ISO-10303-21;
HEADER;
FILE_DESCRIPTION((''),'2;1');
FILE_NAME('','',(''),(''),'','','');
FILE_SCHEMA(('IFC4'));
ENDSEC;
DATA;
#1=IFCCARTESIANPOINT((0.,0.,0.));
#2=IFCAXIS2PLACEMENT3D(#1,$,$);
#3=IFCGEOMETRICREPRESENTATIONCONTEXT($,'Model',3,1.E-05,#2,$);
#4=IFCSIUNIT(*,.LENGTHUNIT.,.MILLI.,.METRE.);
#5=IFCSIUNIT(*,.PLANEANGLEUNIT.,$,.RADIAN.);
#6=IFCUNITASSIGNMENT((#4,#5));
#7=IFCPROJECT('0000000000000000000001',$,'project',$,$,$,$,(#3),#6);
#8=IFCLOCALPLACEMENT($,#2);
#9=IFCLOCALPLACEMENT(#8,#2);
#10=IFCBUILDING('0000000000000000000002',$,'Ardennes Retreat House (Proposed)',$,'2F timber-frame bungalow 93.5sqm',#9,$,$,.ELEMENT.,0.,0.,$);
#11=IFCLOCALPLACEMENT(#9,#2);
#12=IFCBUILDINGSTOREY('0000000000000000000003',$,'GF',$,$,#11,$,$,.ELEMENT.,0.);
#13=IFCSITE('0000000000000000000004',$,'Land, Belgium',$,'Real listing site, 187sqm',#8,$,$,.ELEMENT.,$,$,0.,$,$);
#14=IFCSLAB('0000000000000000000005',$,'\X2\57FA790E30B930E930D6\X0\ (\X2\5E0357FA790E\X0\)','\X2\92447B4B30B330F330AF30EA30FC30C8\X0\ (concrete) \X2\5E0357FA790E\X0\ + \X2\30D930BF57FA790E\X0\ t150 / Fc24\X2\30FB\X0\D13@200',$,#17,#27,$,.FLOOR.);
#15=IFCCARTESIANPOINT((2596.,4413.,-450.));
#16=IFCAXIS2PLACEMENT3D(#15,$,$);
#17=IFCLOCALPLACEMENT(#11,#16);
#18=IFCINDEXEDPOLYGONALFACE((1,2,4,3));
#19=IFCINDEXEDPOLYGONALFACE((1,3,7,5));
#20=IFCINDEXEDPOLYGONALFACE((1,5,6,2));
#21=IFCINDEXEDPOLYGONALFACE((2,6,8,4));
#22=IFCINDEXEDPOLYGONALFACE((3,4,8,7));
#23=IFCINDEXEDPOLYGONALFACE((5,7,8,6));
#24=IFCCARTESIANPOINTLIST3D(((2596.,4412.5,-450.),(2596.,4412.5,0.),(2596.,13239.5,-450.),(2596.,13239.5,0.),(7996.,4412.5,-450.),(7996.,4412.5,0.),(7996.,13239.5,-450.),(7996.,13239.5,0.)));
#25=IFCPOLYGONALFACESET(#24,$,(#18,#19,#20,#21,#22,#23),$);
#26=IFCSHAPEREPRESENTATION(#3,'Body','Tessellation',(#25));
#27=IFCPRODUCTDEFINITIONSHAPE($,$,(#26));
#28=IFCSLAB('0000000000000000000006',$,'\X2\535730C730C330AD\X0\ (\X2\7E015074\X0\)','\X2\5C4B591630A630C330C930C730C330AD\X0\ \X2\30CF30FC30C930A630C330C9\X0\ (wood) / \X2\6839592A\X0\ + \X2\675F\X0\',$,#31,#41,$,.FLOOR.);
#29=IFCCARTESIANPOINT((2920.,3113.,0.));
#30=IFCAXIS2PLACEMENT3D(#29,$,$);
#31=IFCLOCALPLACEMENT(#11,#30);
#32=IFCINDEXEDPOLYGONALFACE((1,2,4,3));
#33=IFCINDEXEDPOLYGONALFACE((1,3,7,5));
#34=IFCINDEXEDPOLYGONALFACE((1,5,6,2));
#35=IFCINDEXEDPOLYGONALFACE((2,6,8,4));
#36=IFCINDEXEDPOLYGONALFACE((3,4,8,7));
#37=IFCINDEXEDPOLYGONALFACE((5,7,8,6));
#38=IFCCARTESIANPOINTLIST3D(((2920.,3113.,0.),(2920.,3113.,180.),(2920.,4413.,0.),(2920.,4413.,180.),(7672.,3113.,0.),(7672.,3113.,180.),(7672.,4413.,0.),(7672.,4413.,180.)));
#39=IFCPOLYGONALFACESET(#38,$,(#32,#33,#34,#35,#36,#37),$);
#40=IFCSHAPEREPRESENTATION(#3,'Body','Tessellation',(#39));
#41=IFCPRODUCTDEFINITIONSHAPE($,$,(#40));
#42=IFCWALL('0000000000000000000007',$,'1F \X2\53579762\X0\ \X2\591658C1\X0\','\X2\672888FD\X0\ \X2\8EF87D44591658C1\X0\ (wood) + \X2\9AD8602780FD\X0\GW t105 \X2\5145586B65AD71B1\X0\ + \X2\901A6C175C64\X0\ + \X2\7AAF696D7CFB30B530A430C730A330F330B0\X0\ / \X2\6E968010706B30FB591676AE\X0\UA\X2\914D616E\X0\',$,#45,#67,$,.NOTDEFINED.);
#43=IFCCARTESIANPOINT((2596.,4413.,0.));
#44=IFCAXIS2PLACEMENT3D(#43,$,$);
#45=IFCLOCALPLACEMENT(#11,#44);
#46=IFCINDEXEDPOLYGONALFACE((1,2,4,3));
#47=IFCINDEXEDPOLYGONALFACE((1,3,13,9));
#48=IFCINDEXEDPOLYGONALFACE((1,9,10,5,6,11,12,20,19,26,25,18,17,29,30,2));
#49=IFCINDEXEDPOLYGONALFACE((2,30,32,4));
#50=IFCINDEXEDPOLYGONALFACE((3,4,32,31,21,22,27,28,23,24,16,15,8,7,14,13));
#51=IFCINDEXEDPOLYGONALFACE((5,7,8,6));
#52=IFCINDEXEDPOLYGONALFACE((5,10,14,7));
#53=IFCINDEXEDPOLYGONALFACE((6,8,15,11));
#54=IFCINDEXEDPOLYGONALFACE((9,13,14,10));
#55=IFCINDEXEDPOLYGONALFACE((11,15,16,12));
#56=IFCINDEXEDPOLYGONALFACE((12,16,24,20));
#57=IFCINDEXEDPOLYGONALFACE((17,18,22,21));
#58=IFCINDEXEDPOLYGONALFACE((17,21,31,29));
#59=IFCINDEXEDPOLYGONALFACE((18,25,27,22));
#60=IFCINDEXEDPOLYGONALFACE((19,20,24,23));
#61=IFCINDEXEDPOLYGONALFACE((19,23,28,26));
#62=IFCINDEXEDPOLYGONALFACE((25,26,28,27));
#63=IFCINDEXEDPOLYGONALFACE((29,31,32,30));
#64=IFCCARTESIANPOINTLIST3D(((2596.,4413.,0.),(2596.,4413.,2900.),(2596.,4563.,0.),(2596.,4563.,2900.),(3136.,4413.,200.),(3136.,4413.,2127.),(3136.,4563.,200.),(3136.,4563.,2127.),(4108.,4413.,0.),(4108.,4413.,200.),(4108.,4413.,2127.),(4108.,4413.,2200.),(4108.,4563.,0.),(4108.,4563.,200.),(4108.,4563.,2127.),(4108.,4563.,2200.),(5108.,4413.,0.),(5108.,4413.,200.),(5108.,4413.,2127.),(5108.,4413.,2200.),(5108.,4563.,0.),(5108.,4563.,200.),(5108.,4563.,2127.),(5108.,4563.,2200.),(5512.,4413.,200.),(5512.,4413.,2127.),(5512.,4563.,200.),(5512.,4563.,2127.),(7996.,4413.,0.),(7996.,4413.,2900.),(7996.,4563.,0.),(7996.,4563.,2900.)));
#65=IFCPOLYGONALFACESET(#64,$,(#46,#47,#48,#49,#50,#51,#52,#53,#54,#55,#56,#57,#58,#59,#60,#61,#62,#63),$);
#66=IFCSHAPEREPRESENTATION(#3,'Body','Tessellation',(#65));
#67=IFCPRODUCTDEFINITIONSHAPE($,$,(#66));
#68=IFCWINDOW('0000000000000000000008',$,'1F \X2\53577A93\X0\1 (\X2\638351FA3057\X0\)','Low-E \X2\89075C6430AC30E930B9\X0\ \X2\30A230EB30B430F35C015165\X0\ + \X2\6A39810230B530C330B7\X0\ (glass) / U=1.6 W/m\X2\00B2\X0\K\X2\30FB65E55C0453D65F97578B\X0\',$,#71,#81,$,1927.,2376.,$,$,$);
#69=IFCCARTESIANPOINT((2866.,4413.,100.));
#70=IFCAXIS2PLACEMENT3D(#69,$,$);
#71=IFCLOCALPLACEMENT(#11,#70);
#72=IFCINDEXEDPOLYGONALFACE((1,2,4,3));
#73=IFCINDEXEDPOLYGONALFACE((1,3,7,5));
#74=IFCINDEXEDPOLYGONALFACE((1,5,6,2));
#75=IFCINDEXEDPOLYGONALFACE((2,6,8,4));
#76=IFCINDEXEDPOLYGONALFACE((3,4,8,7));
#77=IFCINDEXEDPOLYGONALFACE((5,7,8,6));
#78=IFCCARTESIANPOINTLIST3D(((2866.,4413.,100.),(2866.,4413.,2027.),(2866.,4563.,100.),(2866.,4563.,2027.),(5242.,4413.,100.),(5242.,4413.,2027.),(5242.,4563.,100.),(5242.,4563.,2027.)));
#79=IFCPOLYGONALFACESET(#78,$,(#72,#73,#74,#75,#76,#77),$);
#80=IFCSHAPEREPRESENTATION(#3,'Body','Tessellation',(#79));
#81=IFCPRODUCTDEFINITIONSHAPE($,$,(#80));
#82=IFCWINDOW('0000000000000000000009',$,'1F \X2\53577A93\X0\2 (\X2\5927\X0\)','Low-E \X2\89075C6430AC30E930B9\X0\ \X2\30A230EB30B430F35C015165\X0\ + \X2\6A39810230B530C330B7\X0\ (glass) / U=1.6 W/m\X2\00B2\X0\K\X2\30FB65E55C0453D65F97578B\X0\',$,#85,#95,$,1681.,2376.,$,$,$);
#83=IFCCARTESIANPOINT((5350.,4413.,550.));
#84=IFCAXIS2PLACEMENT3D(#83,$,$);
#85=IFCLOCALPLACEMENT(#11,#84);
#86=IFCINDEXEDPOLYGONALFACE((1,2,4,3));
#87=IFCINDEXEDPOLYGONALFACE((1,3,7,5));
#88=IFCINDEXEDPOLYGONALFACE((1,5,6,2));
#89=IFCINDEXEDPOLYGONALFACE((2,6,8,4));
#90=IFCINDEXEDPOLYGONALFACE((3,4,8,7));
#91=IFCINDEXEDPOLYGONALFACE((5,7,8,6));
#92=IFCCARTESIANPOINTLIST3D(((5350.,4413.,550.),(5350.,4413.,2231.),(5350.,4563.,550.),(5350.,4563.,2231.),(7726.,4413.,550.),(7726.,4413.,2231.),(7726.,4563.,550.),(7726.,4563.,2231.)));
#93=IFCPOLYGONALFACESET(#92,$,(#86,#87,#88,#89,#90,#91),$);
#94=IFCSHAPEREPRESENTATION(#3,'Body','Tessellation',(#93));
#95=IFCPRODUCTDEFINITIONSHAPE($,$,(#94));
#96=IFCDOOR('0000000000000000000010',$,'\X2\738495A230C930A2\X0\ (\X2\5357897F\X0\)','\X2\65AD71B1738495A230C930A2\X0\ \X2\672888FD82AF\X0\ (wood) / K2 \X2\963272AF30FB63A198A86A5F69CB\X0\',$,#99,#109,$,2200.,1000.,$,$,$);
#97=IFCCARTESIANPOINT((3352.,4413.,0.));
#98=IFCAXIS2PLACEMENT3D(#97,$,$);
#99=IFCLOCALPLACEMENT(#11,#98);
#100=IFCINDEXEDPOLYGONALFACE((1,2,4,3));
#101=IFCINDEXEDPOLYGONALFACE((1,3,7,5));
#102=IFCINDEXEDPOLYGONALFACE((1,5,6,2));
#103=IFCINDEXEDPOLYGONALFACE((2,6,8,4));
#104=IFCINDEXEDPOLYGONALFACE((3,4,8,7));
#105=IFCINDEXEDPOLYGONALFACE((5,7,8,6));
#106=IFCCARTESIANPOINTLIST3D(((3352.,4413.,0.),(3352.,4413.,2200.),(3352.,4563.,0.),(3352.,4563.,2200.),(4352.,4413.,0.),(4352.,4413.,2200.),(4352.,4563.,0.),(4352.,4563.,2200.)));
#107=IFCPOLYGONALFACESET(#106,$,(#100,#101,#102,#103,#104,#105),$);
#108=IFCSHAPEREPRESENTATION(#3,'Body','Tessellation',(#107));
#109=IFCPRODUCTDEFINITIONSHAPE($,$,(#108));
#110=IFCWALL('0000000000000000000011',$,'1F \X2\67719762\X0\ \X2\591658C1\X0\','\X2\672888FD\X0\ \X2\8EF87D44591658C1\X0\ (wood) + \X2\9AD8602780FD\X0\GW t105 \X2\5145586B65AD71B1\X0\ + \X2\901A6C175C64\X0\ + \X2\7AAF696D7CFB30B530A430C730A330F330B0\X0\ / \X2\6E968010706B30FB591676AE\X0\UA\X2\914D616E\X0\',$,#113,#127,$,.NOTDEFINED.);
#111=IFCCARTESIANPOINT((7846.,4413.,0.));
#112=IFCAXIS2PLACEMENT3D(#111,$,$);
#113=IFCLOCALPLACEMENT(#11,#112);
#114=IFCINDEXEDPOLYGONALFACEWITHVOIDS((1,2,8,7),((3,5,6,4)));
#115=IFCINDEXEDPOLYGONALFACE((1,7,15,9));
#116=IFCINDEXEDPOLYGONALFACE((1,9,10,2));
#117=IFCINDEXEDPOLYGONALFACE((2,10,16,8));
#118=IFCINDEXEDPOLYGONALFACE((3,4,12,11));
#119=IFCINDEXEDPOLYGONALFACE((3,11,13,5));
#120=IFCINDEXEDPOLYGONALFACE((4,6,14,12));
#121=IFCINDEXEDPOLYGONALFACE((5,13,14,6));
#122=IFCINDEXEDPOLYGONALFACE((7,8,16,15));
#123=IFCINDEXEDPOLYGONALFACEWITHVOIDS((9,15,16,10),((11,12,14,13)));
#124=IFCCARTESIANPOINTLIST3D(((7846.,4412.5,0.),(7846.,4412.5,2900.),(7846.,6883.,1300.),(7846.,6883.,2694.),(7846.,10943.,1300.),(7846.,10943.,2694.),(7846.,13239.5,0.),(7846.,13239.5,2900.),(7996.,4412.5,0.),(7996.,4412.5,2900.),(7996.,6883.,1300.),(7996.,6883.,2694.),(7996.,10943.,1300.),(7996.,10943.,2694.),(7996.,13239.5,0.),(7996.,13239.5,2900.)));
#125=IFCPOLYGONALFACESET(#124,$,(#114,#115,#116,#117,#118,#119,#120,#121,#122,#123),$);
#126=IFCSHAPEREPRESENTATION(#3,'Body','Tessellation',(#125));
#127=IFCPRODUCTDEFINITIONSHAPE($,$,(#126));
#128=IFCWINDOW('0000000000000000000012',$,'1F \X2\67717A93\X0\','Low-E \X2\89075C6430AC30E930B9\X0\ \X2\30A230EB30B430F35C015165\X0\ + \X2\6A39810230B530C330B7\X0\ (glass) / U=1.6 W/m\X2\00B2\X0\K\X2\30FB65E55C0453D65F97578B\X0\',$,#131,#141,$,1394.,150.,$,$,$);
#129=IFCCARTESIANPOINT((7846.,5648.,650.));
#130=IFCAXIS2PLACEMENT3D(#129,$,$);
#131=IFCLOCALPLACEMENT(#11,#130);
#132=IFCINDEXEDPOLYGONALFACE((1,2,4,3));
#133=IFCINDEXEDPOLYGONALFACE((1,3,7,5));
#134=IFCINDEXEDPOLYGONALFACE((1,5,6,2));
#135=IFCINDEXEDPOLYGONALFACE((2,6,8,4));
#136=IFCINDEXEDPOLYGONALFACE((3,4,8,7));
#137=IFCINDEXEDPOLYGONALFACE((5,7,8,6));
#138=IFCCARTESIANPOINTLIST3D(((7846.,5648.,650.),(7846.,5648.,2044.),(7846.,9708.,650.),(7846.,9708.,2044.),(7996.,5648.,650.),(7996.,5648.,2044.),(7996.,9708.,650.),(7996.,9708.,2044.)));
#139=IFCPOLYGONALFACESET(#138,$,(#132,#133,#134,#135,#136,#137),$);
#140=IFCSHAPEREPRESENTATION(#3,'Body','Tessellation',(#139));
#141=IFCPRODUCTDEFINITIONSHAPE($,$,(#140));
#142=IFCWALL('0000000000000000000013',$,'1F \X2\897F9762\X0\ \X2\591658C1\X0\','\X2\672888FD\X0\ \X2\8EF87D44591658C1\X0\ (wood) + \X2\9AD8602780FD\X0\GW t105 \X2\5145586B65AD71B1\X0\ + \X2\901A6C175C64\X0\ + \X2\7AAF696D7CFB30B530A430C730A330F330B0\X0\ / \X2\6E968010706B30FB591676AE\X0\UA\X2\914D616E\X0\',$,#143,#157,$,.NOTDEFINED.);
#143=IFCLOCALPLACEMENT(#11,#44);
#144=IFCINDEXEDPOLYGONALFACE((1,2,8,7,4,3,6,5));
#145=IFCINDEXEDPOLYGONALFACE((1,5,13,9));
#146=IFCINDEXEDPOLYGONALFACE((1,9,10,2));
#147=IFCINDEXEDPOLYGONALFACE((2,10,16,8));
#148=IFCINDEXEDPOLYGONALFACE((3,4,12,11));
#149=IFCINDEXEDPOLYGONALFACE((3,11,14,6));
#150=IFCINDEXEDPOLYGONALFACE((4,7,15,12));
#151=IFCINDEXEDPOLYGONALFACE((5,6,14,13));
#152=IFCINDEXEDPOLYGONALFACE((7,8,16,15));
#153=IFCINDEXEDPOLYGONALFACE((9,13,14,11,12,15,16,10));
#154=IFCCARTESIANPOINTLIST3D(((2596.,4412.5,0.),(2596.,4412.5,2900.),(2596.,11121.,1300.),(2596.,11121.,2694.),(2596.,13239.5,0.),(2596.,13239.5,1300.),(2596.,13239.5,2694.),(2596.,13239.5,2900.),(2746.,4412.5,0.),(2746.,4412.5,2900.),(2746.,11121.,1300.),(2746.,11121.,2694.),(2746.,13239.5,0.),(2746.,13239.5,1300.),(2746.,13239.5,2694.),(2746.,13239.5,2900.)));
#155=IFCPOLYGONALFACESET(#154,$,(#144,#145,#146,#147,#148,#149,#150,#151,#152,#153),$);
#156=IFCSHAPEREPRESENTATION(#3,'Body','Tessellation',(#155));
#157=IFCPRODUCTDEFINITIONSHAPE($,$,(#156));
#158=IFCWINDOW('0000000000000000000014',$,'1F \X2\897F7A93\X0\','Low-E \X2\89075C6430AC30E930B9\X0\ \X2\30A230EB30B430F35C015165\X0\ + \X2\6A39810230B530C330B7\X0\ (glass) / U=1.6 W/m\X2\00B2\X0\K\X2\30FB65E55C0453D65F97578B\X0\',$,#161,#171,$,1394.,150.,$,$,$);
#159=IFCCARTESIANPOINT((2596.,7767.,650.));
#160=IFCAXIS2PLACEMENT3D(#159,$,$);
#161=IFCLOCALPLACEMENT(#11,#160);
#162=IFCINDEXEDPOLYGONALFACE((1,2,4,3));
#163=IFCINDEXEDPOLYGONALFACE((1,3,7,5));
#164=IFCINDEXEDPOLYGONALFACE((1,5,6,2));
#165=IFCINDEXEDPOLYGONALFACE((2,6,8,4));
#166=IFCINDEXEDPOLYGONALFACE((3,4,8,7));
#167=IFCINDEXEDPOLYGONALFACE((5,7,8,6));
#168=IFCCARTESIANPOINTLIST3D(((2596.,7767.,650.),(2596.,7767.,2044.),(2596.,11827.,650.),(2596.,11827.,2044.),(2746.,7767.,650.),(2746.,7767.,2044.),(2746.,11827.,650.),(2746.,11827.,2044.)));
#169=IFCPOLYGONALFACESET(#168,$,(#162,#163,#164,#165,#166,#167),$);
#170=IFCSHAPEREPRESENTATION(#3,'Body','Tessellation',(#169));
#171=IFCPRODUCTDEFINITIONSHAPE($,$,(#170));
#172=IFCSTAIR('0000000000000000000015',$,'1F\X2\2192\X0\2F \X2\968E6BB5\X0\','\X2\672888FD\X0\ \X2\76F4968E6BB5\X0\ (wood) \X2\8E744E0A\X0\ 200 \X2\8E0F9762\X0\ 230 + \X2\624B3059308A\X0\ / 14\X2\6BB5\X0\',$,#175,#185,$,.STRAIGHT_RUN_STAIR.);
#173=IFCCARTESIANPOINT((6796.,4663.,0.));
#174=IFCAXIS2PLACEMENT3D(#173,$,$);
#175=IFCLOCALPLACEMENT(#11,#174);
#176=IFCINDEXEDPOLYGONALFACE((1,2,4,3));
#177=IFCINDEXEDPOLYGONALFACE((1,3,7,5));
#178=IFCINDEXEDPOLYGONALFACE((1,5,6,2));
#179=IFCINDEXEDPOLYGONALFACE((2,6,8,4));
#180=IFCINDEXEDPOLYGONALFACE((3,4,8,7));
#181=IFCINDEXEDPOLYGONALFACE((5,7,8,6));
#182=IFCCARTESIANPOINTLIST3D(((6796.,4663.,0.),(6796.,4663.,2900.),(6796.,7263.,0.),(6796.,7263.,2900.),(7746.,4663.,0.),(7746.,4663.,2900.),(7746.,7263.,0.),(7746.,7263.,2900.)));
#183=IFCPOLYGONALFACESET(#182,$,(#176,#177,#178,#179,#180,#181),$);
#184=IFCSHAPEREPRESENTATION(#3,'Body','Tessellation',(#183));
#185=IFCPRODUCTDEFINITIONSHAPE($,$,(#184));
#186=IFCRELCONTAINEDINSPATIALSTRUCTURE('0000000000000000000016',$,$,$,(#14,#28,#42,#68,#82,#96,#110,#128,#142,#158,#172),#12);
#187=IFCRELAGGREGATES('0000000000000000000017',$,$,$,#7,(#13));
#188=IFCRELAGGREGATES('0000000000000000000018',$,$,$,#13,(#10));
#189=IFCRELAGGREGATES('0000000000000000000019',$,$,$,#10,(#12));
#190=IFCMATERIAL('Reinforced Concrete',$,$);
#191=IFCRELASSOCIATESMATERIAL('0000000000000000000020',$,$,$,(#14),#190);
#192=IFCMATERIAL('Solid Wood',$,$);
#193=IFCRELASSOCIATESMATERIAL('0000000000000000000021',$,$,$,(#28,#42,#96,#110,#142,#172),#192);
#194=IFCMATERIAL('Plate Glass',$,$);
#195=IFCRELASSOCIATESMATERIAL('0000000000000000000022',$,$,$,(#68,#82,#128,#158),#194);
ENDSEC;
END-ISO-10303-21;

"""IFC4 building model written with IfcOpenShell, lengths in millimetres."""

from ifc_helpers import new_model, si_unit, frame, frame_2d, origin, place, context, project, spatial, rectangle, extrude, material, element, fill, save


model = new_model("IFC4")

# Units and contexts
model_context = context("Model", 3, precision=1e-05, world=origin())
ifc_project = project(units=[si_unit("LENGTHUNIT", "METRE", prefix="MILLI"), si_unit("PLANEANGLEUNIT", "RADIAN")], contexts=[model_context])

# Site, building, storey
site_placement = place(None, origin())
site = spatial("IfcSite", under=ifc_project, at=site_placement, Name="Land, Belgium", ObjectType="Real listing site, 187sqm", CompositionType="ELEMENT", RefElevation=0.0)
building_placement = place(site_placement, origin())
building = spatial("IfcBuilding", under=site, at=building_placement, Name="Ardennes Retreat House (Proposed)", ObjectType="2F timber-frame bungalow 93.5sqm", CompositionType="ELEMENT", ElevationOfRefHeight=0.0, ElevationOfTerrain=0.0)
storey_placement = place(building_placement, origin())
storey = spatial("IfcBuildingStorey", under=building, at=storey_placement, Name="GF", CompositionType="ELEMENT", Elevation=0.0)

# Slabs
ifc_material_1 = material(Name="Reinforced Concrete")
slab_1_placement = place(storey_placement, frame((2596.0, 4413.0, -450.0)))
element("IfcSlab", 1, at=slab_1_placement, inside=storey, material=ifc_material_1, Name="基礎スラブ (布基礎)", Description="鉄筋コンクリート (concrete) 布基礎 + ベタ基礎 t150 / Fc24・D13@200", PredefinedType="FLOOR", context=model_context, shape_type="SweptSolid", body=[
    extrude(rectangle(XDim=5400.0, YDim=8827.0, at=frame_2d((2700.0, 4413.0))), frame((2596.0, 4413.0, -450.0)), (0.0, 0.0, 1.0), 450.0),
])
ifc_material_2 = material(Name="Solid Wood")
slab_2_placement = place(storey_placement, frame((2920.0, 3113.0, 0.0)))
element("IfcSlab", 2, at=slab_2_placement, inside=storey, material=ifc_material_2, Name="南デッキ (縁側)", Description="屋外ウッドデッキ ハードウッド (wood) / 根太 + 束", PredefinedType="FLOOR", context=model_context, shape_type="SweptSolid", body=[
    extrude(rectangle(XDim=4752.0, YDim=1300.0, at=frame_2d((2376.0, 650.0))), frame((2920.0, 3113.0, 0.0)), (0.0, 0.0, 1.0), 180.0),
])

# Wall, openings, windows, door
wall_1_placement = place(storey_placement, frame((2596.0, 4413.0, 0.0)))
wall_1 = element("IfcWall", 3, at=wall_1_placement, inside=storey, material=ifc_material_2, Name="1F 南面 外壁", Description="木製 軸組外壁 (wood) + 高性能GW t105 充填断熱 + 通気層 + 窯業系サイディング / 準耐火・外皮UA配慮", PredefinedType="NOTDEFINED", context=model_context, shape_type="SweptSolid", body=[
    extrude(rectangle(XDim=5400.0, YDim=150.0, at=frame_2d((2700.0, 75.0))), frame((2596.0, 4413.0, 0.0)), (0.0, 0.0, 1.0), 2900.0),
])
opening_1_placement = place(storey_placement, frame((2866.0, 4413.0, 100.0)))
opening_1 = element("IfcOpeningElement", 4, at=opening_1_placement, cuts=wall_1, PredefinedType="NOTDEFINED", context=model_context, shape_type="SweptSolid", body=[
    extrude(rectangle(XDim=2376.0, YDim=150.0, at=frame_2d((1188.0, 75.0))), frame((2866.0, 4413.0, 100.0)), (0.0, 0.0, 1.0), 1927.0),
])
opening_2_placement = place(storey_placement, frame((5350.0, 4413.0, 550.0)))
opening_2 = element("IfcOpeningElement", 5, at=opening_2_placement, cuts=wall_1, PredefinedType="NOTDEFINED", context=model_context, shape_type="SweptSolid", body=[
    extrude(rectangle(XDim=2376.0, YDim=150.0, at=frame_2d((1188.0, 75.0))), frame((5350.0, 4413.0, 550.0)), (0.0, 0.0, 1.0), 1681.0),
])
opening_3_placement = place(storey_placement, frame((3352.0, 4413.0, 0.0)))
opening_3 = element("IfcOpeningElement", 6, at=opening_3_placement, cuts=wall_1, PredefinedType="NOTDEFINED", context=model_context, shape_type="SweptSolid", body=[
    extrude(rectangle(XDim=1000.0, YDim=150.0, at=frame_2d((500.0, 75.0))), frame((3352.0, 4413.0, 0.0)), (0.0, 0.0, 1.0), 2200.0),
])
ifc_material_3 = material(Name="Plate Glass")
window_1_placement = place(storey_placement, frame((2866.0, 4413.0, 100.0)))
window_1 = element("IfcWindow", 7, at=window_1_placement, inside=storey, material=ifc_material_3, Name="1F 南窓1 (掃出し)", Description="Low-E 複層ガラス アルゴン封入 + 樹脂サッシ (glass) / U=1.6 W/m²K・日射取得型", OverallHeight=1927.0, OverallWidth=2376.0, context=model_context, shape_type="SweptSolid", body=[
    extrude(rectangle(XDim=2376.0, YDim=150.0, at=frame_2d((1188.0, 75.0))), frame((2866.0, 4413.0, 100.0)), (0.0, 0.0, 1.0), 1927.0),
])
fill(opening_1, window_1)
window_2_placement = place(storey_placement, frame((5350.0, 4413.0, 550.0)))
window_2 = element("IfcWindow", 8, at=window_2_placement, inside=storey, material=ifc_material_3, Name="1F 南窓2 (大)", Description="Low-E 複層ガラス アルゴン封入 + 樹脂サッシ (glass) / U=1.6 W/m²K・日射取得型", OverallHeight=1681.0, OverallWidth=2376.0, context=model_context, shape_type="SweptSolid", body=[
    extrude(rectangle(XDim=2376.0, YDim=150.0, at=frame_2d((1188.0, 75.0))), frame((5350.0, 4413.0, 550.0)), (0.0, 0.0, 1.0), 1681.0),
])
fill(opening_2, window_2)
door_placement = place(storey_placement, frame((3352.0, 4413.0, 0.0)))
door = element("IfcDoor", 9, at=door_placement, inside=storey, material=ifc_material_2, Name="玄関ドア (南西)", Description="断熱玄関ドア 木製芯 (wood) / K2 防犯・採風機構", OverallHeight=2200.0, OverallWidth=1000.0, context=model_context, shape_type="SweptSolid", body=[
    extrude(rectangle(XDim=1000.0, YDim=150.0, at=frame_2d((500.0, 75.0))), frame((3352.0, 4413.0, 0.0)), (0.0, 0.0, 1.0), 2200.0),
])
fill(opening_3, door)

# Walls, openings, windows
wall_2_placement = place(storey_placement, frame((7846.0, 4413.0, 0.0)))
wall_2 = element("IfcWall", 10, at=wall_2_placement, inside=storey, material=ifc_material_2, Name="1F 東面 外壁", Description="木製 軸組外壁 (wood) + 高性能GW t105 充填断熱 + 通気層 + 窯業系サイディング / 準耐火・外皮UA配慮", PredefinedType="NOTDEFINED", context=model_context, shape_type="SweptSolid", body=[
    extrude(rectangle(XDim=150.0, YDim=8827.0, at=frame_2d((75.0, 4413.0))), frame((7846.0, 4413.0, 0.0)), (0.0, 0.0, 1.0), 2900.0),
])
opening_4_placement = place(storey_placement, frame((7846.0, 5648.0, 650.0)))
opening_4 = element("IfcOpeningElement", 11, at=opening_4_placement, cuts=wall_2, PredefinedType="NOTDEFINED", context=model_context, shape_type="SweptSolid", body=[
    extrude(rectangle(XDim=150.0, YDim=4060.0, at=frame_2d((75.0, 2030.0))), frame((7846.0, 5648.0, 650.0)), (0.0, 0.0, 1.0), 1394.0),
])
window_3_placement = place(storey_placement, frame((7846.0, 5648.0, 650.0)))
window_3 = element("IfcWindow", 12, at=window_3_placement, inside=storey, material=ifc_material_3, Name="1F 東窓", Description="Low-E 複層ガラス アルゴン封入 + 樹脂サッシ (glass) / U=1.6 W/m²K・日射取得型", OverallHeight=1394.0, OverallWidth=150.0, context=model_context, shape_type="SweptSolid", body=[
    extrude(rectangle(XDim=150.0, YDim=4060.0, at=frame_2d((75.0, 2030.0))), frame((7846.0, 5648.0, 650.0)), (0.0, 0.0, 1.0), 1394.0),
])
fill(opening_4, window_3)
wall_3_placement = place(storey_placement, frame((2596.0, 4413.0, 0.0)))
wall_3 = element("IfcWall", 13, at=wall_3_placement, inside=storey, material=ifc_material_2, Name="1F 西面 外壁", Description="木製 軸組外壁 (wood) + 高性能GW t105 充填断熱 + 通気層 + 窯業系サイディング / 準耐火・外皮UA配慮", PredefinedType="NOTDEFINED", context=model_context, shape_type="SweptSolid", body=[
    extrude(rectangle(XDim=150.0, YDim=8827.0, at=frame_2d((75.0, 4413.0))), frame((2596.0, 4413.0, 0.0)), (0.0, 0.0, 1.0), 2900.0),
])
opening_5_placement = place(storey_placement, frame((2596.0, 7767.0, 650.0)))
opening_5 = element("IfcOpeningElement", 14, at=opening_5_placement, cuts=wall_3, PredefinedType="NOTDEFINED", context=model_context, shape_type="SweptSolid", body=[
    extrude(rectangle(XDim=150.0, YDim=4060.0, at=frame_2d((75.0, 2030.0))), frame((2596.0, 7767.0, 650.0)), (0.0, 0.0, 1.0), 1394.0),
])
window_4_placement = place(storey_placement, frame((2596.0, 7767.0, 650.0)))
window_4 = element("IfcWindow", 15, at=window_4_placement, inside=storey, material=ifc_material_3, Name="1F 西窓", Description="Low-E 複層ガラス アルゴン封入 + 樹脂サッシ (glass) / U=1.6 W/m²K・日射取得型", OverallHeight=1394.0, OverallWidth=150.0, context=model_context, shape_type="SweptSolid", body=[
    extrude(rectangle(XDim=150.0, YDim=4060.0, at=frame_2d((75.0, 2030.0))), frame((2596.0, 7767.0, 650.0)), (0.0, 0.0, 1.0), 1394.0),
])
fill(opening_5, window_4)

# Stair
stair_placement = place(storey_placement, frame((6796.0, 4663.0, 0.0)))
element("IfcStair", 16, at=stair_placement, inside=storey, material=ifc_material_2, Name="1F→2F 階段", Description="木製 直階段 (wood) 蹴上 200 踏面 230 + 手すり / 14段", PredefinedType="STRAIGHT_RUN_STAIR", context=model_context, shape_type="SweptSolid", body=[
    extrude(rectangle(XDim=950.0, YDim=2600.0, at=frame_2d((475.0, 1300.0))), frame((6796.0, 4663.0, 0.0)), (0.0, 0.0, 1.0), 2900.0),
])

save(model, "model.ifc")
